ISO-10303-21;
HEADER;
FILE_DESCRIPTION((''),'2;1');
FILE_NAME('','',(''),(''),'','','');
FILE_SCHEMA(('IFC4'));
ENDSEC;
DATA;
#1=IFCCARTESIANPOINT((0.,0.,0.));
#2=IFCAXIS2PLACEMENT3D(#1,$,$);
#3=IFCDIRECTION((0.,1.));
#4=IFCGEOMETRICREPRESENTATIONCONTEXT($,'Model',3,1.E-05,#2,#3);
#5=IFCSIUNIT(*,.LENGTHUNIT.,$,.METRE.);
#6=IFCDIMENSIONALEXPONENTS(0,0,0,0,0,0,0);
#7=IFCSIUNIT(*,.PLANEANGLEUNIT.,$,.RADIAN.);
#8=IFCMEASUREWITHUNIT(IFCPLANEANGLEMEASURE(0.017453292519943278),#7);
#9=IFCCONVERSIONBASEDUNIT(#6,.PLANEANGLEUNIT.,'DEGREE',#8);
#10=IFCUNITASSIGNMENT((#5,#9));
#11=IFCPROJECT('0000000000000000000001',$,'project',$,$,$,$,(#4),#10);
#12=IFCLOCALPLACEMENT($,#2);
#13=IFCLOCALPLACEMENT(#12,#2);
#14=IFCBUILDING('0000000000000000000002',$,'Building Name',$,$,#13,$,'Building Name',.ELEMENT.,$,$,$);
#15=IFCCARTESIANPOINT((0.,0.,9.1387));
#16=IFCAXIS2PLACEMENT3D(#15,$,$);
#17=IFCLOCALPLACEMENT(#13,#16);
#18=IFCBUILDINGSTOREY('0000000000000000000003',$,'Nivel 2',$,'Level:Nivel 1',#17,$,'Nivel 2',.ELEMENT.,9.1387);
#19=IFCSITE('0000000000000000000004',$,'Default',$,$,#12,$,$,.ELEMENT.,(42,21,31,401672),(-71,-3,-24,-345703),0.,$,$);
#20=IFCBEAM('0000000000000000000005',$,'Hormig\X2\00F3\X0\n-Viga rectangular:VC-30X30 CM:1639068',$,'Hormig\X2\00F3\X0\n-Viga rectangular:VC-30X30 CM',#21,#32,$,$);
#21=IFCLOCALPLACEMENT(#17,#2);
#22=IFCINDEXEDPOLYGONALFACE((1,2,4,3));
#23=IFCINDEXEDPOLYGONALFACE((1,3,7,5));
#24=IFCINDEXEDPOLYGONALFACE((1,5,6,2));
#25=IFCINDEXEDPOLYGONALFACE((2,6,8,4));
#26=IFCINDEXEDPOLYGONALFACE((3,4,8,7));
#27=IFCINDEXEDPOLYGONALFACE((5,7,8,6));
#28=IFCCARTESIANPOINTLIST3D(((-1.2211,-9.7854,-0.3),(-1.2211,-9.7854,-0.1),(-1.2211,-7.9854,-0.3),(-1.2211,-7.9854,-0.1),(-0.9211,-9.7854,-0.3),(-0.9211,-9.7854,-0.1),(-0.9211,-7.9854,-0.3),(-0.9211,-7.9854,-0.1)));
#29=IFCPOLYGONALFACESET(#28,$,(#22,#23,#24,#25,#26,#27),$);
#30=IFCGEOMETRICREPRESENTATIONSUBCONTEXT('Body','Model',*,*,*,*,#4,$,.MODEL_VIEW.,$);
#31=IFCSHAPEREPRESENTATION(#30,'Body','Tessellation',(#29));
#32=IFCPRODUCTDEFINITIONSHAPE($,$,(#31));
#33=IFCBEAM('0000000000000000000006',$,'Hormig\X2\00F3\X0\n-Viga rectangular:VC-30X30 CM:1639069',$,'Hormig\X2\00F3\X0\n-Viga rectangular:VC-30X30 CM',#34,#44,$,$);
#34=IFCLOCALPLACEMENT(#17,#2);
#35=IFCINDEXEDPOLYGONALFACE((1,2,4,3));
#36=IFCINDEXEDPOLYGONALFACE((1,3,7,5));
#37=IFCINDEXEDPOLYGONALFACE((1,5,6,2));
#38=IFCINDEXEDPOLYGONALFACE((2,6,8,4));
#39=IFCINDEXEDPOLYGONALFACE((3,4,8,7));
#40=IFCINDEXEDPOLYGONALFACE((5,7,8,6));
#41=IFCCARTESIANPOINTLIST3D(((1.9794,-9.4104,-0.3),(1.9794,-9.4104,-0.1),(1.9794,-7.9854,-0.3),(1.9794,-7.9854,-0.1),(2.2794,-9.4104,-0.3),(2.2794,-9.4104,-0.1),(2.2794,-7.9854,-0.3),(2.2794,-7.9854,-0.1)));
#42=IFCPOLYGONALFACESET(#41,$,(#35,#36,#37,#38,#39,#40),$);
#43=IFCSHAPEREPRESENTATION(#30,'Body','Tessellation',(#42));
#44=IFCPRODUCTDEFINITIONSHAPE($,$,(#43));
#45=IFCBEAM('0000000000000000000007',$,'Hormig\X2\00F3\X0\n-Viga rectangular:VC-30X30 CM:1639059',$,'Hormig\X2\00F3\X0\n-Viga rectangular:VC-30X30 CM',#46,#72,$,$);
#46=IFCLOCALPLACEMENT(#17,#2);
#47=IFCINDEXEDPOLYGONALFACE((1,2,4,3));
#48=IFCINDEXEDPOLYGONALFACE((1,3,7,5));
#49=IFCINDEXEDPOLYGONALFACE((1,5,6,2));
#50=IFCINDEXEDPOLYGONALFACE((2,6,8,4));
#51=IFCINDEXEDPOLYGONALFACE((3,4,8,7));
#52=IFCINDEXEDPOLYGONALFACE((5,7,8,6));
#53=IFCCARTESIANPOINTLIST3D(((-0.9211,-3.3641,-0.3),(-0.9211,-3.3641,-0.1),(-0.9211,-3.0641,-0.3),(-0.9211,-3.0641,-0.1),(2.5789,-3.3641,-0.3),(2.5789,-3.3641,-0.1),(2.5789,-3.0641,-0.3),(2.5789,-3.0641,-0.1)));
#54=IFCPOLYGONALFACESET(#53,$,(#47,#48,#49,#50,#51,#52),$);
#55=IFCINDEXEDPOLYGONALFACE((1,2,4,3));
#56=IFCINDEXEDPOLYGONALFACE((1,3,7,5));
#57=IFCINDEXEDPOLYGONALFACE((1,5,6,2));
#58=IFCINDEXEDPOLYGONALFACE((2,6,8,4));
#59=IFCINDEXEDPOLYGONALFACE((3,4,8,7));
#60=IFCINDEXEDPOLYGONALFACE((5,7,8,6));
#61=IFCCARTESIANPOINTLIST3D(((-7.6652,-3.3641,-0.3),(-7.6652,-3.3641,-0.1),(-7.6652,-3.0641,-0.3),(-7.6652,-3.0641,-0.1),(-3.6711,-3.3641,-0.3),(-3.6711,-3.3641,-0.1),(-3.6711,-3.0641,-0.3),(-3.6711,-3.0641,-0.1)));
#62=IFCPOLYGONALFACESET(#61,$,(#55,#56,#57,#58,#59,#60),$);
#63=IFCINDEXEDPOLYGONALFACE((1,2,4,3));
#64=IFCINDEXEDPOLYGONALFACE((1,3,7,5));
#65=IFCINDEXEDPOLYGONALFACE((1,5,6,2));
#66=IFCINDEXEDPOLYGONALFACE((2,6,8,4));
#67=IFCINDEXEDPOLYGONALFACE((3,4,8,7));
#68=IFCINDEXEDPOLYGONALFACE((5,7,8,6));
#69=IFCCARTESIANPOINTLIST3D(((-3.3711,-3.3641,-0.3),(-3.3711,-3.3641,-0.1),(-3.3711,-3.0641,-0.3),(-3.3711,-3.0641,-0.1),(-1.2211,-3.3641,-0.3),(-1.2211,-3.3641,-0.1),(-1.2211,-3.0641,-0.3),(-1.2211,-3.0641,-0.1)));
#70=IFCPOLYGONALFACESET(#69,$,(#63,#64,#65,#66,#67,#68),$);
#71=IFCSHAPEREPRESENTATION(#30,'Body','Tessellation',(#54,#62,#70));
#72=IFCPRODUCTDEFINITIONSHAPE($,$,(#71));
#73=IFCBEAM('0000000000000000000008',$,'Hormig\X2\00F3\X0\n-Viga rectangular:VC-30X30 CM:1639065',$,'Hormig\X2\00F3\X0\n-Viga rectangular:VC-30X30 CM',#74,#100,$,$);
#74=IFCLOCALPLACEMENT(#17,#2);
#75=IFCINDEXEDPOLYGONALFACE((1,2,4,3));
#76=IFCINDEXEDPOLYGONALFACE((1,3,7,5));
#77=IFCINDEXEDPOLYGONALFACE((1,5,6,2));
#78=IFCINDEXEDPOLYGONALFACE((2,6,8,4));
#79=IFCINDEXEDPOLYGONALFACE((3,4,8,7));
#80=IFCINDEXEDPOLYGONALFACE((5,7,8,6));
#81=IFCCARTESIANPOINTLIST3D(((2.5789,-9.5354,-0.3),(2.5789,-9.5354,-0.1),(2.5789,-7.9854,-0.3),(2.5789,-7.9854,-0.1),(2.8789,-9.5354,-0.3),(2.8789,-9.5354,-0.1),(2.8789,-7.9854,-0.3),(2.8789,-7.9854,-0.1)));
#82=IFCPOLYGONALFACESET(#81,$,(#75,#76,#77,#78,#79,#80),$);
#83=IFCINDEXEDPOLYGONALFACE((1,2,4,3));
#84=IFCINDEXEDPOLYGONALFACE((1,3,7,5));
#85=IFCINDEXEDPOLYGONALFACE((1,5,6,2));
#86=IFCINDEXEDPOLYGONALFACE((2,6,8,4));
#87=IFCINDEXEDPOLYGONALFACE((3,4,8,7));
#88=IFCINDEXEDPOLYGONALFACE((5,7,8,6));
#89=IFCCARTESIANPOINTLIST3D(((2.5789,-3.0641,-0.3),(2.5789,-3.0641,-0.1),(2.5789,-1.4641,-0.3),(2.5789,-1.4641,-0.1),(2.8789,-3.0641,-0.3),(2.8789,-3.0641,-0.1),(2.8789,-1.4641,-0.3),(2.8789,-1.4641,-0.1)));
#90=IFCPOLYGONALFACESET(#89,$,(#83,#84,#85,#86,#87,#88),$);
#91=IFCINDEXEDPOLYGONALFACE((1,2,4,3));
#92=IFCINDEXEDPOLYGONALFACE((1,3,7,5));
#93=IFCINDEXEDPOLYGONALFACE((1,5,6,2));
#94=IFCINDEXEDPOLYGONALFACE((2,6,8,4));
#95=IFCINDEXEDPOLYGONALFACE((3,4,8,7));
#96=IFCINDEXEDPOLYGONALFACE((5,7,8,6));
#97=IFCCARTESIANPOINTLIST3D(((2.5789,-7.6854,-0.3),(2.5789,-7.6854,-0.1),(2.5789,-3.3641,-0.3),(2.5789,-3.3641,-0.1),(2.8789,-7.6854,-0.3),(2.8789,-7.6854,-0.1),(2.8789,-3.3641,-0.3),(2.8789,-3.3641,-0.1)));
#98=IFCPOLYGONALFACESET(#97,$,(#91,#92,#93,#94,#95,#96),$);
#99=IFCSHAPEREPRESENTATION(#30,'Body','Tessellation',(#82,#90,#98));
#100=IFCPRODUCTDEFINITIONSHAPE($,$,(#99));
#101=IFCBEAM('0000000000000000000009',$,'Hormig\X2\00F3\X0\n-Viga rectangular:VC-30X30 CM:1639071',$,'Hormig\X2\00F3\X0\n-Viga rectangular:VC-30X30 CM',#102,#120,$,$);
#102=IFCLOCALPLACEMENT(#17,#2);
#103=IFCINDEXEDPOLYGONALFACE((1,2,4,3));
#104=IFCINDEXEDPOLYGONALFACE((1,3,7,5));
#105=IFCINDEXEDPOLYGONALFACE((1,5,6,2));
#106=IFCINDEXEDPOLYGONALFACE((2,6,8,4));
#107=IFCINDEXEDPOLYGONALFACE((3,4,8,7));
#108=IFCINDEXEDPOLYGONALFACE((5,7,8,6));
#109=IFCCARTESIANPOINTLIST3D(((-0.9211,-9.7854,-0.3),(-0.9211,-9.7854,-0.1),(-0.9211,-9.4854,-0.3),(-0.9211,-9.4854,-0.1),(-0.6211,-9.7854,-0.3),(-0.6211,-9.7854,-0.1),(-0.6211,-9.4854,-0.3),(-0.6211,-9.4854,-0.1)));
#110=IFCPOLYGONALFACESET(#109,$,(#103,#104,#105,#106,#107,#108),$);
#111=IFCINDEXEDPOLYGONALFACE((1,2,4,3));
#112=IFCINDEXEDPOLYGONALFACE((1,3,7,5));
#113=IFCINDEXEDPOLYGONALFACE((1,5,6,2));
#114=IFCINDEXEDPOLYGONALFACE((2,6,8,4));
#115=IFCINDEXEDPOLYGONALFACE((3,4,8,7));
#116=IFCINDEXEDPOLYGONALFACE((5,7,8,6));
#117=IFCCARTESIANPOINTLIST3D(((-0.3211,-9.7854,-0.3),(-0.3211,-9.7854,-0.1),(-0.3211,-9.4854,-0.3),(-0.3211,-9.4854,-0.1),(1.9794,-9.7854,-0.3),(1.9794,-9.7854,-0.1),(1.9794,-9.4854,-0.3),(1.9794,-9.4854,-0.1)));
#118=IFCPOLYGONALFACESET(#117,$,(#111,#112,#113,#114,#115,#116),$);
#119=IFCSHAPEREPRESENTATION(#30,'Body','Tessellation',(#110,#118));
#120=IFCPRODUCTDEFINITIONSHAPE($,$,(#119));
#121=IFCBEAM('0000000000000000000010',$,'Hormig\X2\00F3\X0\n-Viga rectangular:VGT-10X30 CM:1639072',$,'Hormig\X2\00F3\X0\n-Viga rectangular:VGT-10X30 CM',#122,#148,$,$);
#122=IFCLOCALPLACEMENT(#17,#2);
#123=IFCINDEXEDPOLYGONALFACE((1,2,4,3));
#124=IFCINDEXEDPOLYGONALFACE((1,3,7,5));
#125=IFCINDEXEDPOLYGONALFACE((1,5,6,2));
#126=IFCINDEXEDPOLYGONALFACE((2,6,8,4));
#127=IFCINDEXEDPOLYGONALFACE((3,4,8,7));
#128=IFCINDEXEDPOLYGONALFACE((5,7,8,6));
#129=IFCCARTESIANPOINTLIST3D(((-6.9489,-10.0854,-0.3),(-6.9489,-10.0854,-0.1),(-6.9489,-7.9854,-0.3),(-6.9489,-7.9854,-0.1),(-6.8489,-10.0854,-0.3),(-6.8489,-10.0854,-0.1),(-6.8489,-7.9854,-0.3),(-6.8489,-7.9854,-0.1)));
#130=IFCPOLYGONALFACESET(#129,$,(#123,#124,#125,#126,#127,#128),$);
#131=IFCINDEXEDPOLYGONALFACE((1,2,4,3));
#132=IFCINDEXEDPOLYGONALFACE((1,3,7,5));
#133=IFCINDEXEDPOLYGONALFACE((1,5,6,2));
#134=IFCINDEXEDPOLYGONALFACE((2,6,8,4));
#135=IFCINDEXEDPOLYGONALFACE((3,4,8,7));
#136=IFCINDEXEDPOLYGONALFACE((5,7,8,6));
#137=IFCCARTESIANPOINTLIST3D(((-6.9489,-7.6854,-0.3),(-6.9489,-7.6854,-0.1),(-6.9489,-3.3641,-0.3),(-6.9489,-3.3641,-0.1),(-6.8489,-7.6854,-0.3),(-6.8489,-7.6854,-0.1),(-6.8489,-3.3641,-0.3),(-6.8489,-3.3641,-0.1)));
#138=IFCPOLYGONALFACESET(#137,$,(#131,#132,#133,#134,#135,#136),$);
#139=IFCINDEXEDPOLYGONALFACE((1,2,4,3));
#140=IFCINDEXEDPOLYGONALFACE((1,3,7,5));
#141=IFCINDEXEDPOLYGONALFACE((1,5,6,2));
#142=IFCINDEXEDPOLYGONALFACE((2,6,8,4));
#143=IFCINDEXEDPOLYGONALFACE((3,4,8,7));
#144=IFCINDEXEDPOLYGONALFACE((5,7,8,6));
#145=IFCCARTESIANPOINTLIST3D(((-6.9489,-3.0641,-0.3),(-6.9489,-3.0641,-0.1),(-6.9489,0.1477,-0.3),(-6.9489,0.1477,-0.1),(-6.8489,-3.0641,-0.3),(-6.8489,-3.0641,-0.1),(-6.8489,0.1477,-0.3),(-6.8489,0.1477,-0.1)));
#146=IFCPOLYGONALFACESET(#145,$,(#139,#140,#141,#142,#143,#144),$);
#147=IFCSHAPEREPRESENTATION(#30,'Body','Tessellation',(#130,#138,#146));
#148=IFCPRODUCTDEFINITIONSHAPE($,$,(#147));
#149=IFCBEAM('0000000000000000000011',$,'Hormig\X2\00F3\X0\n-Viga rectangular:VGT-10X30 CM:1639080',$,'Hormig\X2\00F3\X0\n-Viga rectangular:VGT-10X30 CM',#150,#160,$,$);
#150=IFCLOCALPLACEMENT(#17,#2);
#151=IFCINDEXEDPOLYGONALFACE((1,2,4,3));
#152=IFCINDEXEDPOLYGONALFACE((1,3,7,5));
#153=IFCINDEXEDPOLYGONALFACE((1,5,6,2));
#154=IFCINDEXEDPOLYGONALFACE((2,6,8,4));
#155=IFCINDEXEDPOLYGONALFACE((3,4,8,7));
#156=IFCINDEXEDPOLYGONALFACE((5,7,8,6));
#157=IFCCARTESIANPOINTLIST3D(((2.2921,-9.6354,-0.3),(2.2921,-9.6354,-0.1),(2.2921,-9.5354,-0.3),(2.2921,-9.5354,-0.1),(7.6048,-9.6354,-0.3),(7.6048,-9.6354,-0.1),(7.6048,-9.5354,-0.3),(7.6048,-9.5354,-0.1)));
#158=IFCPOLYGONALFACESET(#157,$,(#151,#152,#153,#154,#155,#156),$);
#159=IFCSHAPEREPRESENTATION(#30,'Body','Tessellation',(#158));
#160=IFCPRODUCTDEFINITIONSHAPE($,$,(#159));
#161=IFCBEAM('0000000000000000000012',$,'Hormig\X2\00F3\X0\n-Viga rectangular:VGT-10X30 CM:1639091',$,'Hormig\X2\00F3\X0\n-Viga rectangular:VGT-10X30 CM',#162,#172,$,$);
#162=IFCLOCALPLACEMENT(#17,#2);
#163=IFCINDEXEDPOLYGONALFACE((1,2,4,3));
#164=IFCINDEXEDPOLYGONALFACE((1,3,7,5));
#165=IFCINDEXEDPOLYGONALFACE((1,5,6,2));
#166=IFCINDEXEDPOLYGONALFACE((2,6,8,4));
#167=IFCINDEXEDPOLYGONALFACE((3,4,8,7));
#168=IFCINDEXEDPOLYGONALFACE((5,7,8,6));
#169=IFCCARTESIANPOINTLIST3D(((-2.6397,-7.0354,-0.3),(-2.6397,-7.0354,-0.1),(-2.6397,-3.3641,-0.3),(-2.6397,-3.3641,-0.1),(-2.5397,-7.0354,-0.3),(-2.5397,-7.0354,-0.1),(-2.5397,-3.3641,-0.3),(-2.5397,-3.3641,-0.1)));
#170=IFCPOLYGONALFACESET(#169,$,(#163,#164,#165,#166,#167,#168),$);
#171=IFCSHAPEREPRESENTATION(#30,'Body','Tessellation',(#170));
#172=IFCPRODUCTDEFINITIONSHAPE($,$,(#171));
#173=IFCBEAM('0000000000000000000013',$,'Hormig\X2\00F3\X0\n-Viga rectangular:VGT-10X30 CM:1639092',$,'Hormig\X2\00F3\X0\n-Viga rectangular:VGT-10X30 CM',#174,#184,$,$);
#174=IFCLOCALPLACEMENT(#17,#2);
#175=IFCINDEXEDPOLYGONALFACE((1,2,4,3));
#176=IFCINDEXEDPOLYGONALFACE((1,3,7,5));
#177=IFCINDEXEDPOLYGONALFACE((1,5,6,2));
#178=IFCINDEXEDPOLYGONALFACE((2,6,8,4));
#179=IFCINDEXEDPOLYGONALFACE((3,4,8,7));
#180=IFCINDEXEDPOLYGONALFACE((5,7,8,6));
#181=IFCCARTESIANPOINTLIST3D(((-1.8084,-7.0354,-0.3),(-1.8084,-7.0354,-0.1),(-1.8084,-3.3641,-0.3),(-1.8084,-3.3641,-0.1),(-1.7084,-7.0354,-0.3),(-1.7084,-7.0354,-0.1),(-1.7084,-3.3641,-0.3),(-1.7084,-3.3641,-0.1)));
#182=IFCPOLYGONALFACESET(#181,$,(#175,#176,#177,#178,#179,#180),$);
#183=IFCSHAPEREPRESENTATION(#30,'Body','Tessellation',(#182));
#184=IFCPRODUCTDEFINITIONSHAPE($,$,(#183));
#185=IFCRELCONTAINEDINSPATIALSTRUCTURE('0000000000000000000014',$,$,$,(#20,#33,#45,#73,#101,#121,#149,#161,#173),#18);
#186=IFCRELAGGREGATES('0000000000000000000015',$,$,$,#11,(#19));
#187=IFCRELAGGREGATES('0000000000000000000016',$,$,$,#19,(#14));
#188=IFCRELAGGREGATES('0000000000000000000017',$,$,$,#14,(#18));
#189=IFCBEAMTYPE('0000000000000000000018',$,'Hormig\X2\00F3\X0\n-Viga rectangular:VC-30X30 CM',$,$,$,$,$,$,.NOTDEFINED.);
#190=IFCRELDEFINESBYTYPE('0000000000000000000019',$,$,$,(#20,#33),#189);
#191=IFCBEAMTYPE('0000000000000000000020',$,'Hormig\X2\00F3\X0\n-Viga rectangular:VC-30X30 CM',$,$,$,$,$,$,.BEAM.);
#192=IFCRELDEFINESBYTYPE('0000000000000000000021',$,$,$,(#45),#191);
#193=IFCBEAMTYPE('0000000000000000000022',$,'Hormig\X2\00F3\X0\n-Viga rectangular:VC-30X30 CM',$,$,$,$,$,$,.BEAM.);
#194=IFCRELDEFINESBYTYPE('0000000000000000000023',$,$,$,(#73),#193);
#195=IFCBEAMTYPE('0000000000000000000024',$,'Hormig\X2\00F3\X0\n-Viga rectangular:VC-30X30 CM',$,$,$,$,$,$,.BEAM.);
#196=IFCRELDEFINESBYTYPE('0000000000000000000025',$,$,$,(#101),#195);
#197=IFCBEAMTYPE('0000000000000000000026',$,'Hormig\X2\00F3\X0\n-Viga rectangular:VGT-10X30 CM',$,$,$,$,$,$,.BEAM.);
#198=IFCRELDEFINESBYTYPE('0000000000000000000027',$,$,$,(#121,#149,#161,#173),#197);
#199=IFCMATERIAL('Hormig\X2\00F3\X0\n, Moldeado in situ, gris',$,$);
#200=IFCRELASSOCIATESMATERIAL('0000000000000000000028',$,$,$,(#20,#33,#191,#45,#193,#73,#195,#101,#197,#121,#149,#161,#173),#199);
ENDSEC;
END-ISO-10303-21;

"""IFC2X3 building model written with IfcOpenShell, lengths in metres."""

from ifc_helpers import new_model, entity, si_unit, converted_unit, direction, frame, frame_2d, origin, place, context, subcontext, project, spatial, rectangle, extrude, source, transform, mapped, material, type_object, type_shapes, element, save


model = new_model("IFC2X3")

# Units and contexts
model_context = context("Model", 3, precision=1e-05, world=origin(), true_north=direction((0.0, 1.0)))
body_context = subcontext(model_context, "Body", "Model", "MODEL_VIEW")
ifc_project = project(units=[si_unit("LENGTHUNIT", "METRE"), converted_unit("PLANEANGLEUNIT", "DEGREE", entity("IfcPlaneAngleMeasure", 0.017453292519943278), si_unit("PLANEANGLEUNIT", "RADIAN"), dimensions=[0, 0, 0, 0, 0, 0, 0])], contexts=[model_context])

# Site, building, storey
site_placement = place(None, origin())
site = spatial("IfcSite", under=ifc_project, at=site_placement, Name="Default", CompositionType="ELEMENT", RefLatitude=(42, 21, 31, 401672), RefLongitude=(-71, -3, -24, -345703), RefElevation=0.0)
building_placement = place(site_placement, origin())
building = spatial("IfcBuilding", under=site, at=building_placement, Name="Building Name", LongName="Building Name", CompositionType="ELEMENT")
storey_placement = place(building_placement, frame((0.0, 0.0, 9.1387)))
storey = spatial("IfcBuildingStorey", under=building, at=storey_placement, Name="Nivel 2", ObjectType="Level:Nivel 1", LongName="Nivel 2", CompositionType="ELEMENT", Elevation=9.1387)

# Beams
ifc_material = material(Name="Hormigón, Moldeado in situ, gris")
beam_type_1 = type_object("IfcBeamType", Name="Hormigón-Viga rectangular:VC-30X30 CM", PredefinedType="NOTDEFINED")
beam_1_placement = place(storey_placement, frame((-1.0711, -7.8354, 0.0), z_axis=(0.0, 0.0, 1.0), x_axis=(0.0, -1.0, 0.0)))
element("IfcBeam", 1, at=beam_1_placement, inside=storey, type_object=beam_type_1, material=ifc_material, Name="Hormigón-Viga rectangular:VC-30X30 CM:1639068", ObjectType="Hormigón-Viga rectangular:VC-30X30 CM", context=body_context, shape_type="SweptSolid", body=[
    extrude(rectangle(XDim=0.2, YDim=0.3, at=frame_2d((0.0, 0.0), x_axis=(1.0, 0.0))), frame((0.15, 0.0, -0.2), z_axis=(1.0, 0.0, 0.0), x_axis=(0.0, 0.0, -1.0)), (0.0, 0.0, 1.0), 1.8),
])
beam_2_placement = place(storey_placement, frame((2.1294, -7.8354, 0.0), z_axis=(0.0, 0.0, 1.0), x_axis=(0.0, -1.0, 0.0)))
element("IfcBeam", 2, at=beam_2_placement, inside=storey, type_object=beam_type_1, material=ifc_material, Name="Hormigón-Viga rectangular:VC-30X30 CM:1639069", ObjectType="Hormigón-Viga rectangular:VC-30X30 CM", context=body_context, shape_type="SweptSolid", body=[
    extrude(rectangle(XDim=0.2, YDim=0.3, at=frame_2d((0.0, 0.0), x_axis=(1.0, 0.0))), frame((0.15, 0.0, -0.2), z_axis=(1.0, 0.0, 0.0), x_axis=(0.0, 0.0, -1.0)), (0.0, 0.0, 1.0), 1.425),
])
beam_type_2 = type_object("IfcBeamType", Name="Hormigón-Viga rectangular:VC-30X30 CM", PredefinedType="BEAM", material=ifc_material)
shared_shape_1 = source(origin(), body_context, "Body", "SweptSolid", [
    extrude(rectangle(XDim=0.2, YDim=0.3, at=frame_2d((0.0, 0.0), x_axis=(1.0, 0.0))), frame((-0.9211, -3.2141, 8.9387), z_axis=(1.0, 0.0, 0.0), x_axis=(0.0, 0.0, -1.0)), (0.0, 0.0, 1.0), 3.5),
    extrude(rectangle(XDim=0.2, YDim=0.3, at=frame_2d((0.0, 0.0), x_axis=(1.0, 0.0))), frame((-7.6652, -3.2141, 8.9387), z_axis=(1.0, 0.0, 0.0), x_axis=(0.0, 0.0, -1.0)), (0.0, 0.0, 1.0), 3.9942),
    extrude(rectangle(XDim=0.2, YDim=0.3, at=frame_2d((0.0, 0.0), x_axis=(1.0, 0.0))), frame((-3.3711, -3.2141, 8.9387), z_axis=(1.0, 0.0, 0.0), x_axis=(0.0, 0.0, -1.0)), (0.0, 0.0, 1.0), 2.15),
])
type_shapes(beam_type_2, [shared_shape_1])
beam_3_placement = place(storey_placement, frame((0.0, 0.0, -9.1387)))
element("IfcBeam", 3, at=beam_3_placement, inside=storey, type_object=beam_type_2, material=ifc_material, Name="Hormigón-Viga rectangular:VC-30X30 CM:1639059", ObjectType="Hormigón-Viga rectangular:VC-30X30 CM", context=body_context, shape_type="MappedRepresentation", body=[
    mapped(shared_shape_1, transform((0.0, 0.0, 0.0), scale=1.0)),
])
beam_type_3 = type_object("IfcBeamType", Name="Hormigón-Viga rectangular:VC-30X30 CM", PredefinedType="BEAM", material=ifc_material)
shared_shape_2 = source(origin(), body_context, "Body", "SweptSolid", [
    extrude(rectangle(XDim=0.2, YDim=0.3, at=frame_2d((0.0, 0.0), x_axis=(0.0, 1.0))), frame((2.7289, -7.9854, 8.9387), z_axis=(0.0, -1.0, 0.0), x_axis=(-1.0, 0.0, 0.0)), (0.0, 0.0, 1.0), 1.55),
    extrude(rectangle(XDim=0.2, YDim=0.3, at=frame_2d((0.0, 0.0), x_axis=(0.0, 1.0))), frame((2.7289, -1.4641, 8.9387), z_axis=(0.0, -1.0, 0.0), x_axis=(-1.0, 0.0, 0.0)), (0.0, 0.0, 1.0), 1.6),
    extrude(rectangle(XDim=0.2, YDim=0.3, at=frame_2d((0.0, 0.0), x_axis=(0.0, 1.0))), frame((2.7289, -3.3641, 8.9387), z_axis=(0.0, -1.0, 0.0), x_axis=(-1.0, 0.0, 0.0)), (0.0, 0.0, 1.0), 4.3214),
])
type_shapes(beam_type_3, [shared_shape_2])
beam_4_placement = place(storey_placement, frame((0.0, 0.0, -9.1387)))
element("IfcBeam", 4, at=beam_4_placement, inside=storey, type_object=beam_type_3, material=ifc_material, Name="Hormigón-Viga rectangular:VC-30X30 CM:1639065", ObjectType="Hormigón-Viga rectangular:VC-30X30 CM", context=body_context, shape_type="MappedRepresentation", body=[
    mapped(shared_shape_2, transform((0.0, 0.0, 0.0), scale=1.0)),
])
beam_type_4 = type_object("IfcBeamType", Name="Hormigón-Viga rectangular:VC-30X30 CM", PredefinedType="BEAM", material=ifc_material)
shared_shape_3 = source(origin(), body_context, "Body", "SweptSolid", [
    extrude(rectangle(XDim=0.2, YDim=0.3, at=frame_2d((0.0, 0.0), x_axis=(1.0, 0.0))), frame((-0.9211, -9.6354, 8.9387), z_axis=(1.0, 0.0, 0.0), x_axis=(0.0, 0.0, -1.0)), (0.0, 0.0, 1.0), 0.3),
    extrude(rectangle(XDim=0.2, YDim=0.3, at=frame_2d((0.0, 0.0), x_axis=(1.0, 0.0))), frame((-0.3211, -9.6354, 8.9387), z_axis=(1.0, 0.0, 0.0), x_axis=(0.0, 0.0, -1.0)), (0.0, 0.0, 1.0), 2.3005),
])
type_shapes(beam_type_4, [shared_shape_3])
beam_5_placement = place(storey_placement, frame((0.0, 0.0, -9.1387)))
element("IfcBeam", 5, at=beam_5_placement, inside=storey, type_object=beam_type_4, material=ifc_material, Name="Hormigón-Viga rectangular:VC-30X30 CM:1639071", ObjectType="Hormigón-Viga rectangular:VC-30X30 CM", context=body_context, shape_type="MappedRepresentation", body=[
    mapped(shared_shape_3, transform((0.0, 0.0, 0.0), scale=1.0)),
])
beam_type_5 = type_object("IfcBeamType", Name="Hormigón-Viga rectangular:VGT-10X30 CM", PredefinedType="BEAM", material=ifc_material)
shared_shape_4 = source(origin(), body_context, "Body", "SweptSolid", [
    extrude(rectangle(XDim=0.2, YDim=0.1, at=frame_2d((0.0, 0.0), x_axis=(0.0, 1.0))), frame((-6.8989, -7.9854, 8.9387), z_axis=(0.0, -1.0, 0.0), x_axis=(-1.0, 0.0, 0.0)), (0.0, 0.0, 1.0), 2.1),
    extrude(rectangle(XDim=0.2, YDim=0.1, at=frame_2d((0.0, 0.0), x_axis=(0.0, 1.0))), frame((-6.8989, -3.3641, 8.9387), z_axis=(0.0, -1.0, 0.0), x_axis=(-1.0, 0.0, 0.0)), (0.0, 0.0, 1.0), 4.3214),
    extrude(rectangle(XDim=0.2, YDim=0.1, at=frame_2d((0.0, 0.0), x_axis=(0.0, 1.0))), frame((-6.8989, 0.1477, 8.9387), z_axis=(0.0, -1.0, 0.0), x_axis=(-1.0, 0.0, 0.0)), (0.0, 0.0, 1.0), 3.2118),
])
type_shapes(beam_type_5, [shared_shape_4])
beam_6_placement = place(storey_placement, frame((0.0, 0.0, -9.1387)))
element("IfcBeam", 6, at=beam_6_placement, inside=storey, type_object=beam_type_5, material=ifc_material, Name="Hormigón-Viga rectangular:VGT-10X30 CM:1639072", ObjectType="Hormigón-Viga rectangular:VGT-10X30 CM", context=body_context, shape_type="MappedRepresentation", body=[
    mapped(shared_shape_4, transform((0.0, 0.0, 0.0), scale=1.0)),
])
beam_7_placement = place(storey_placement, frame((2.2921, -9.5854, 0.0)))
element("IfcBeam", 7, at=beam_7_placement, inside=storey, type_object=beam_type_5, material=ifc_material, Name="Hormigón-Viga rectangular:VGT-10X30 CM:1639080", ObjectType="Hormigón-Viga rectangular:VGT-10X30 CM", context=body_context, shape_type="SweptSolid", body=[
    extrude(rectangle(XDim=0.2, YDim=0.1, at=frame_2d((0.0, 0.0), x_axis=(1.0, 0.0))), frame((0.0, 0.0, -0.2), z_axis=(1.0, 0.0, 0.0), x_axis=(0.0, 0.0, -1.0)), (0.0, 0.0, 1.0), 5.3126),
])
beam_8_placement = place(storey_placement, frame((-2.5897, -7.1354, 0.0), z_axis=(0.0, 0.0, 1.0), x_axis=(0.0, 1.0, 0.0)))
element("IfcBeam", 8, at=beam_8_placement, inside=storey, type_object=beam_type_5, material=ifc_material, Name="Hormigón-Viga rectangular:VGT-10X30 CM:1639091", ObjectType="Hormigón-Viga rectangular:VGT-10X30 CM", context=body_context, shape_type="SweptSolid", body=[
    extrude(rectangle(XDim=0.2, YDim=0.1, at=frame_2d((0.0, 0.0), x_axis=(1.0, 0.0))), frame((0.1, 0.0, -0.2), z_axis=(1.0, 0.0, 0.0), x_axis=(0.0, 0.0, -1.0)), (0.0, 0.0, 1.0), 3.6714),
])
beam_9_placement = place(storey_placement, frame((-1.7584, -7.1354, 0.0), z_axis=(0.0, 0.0, 1.0), x_axis=(0.0, 1.0, 0.0)))
element("IfcBeam", 9, at=beam_9_placement, inside=storey, type_object=beam_type_5, material=ifc_material, Name="Hormigón-Viga rectangular:VGT-10X30 CM:1639092", ObjectType="Hormigón-Viga rectangular:VGT-10X30 CM", context=body_context, shape_type="SweptSolid", body=[
    extrude(rectangle(XDim=0.2, YDim=0.1, at=frame_2d((0.0, 0.0), x_axis=(1.0, 0.0))), frame((0.1, 0.0, -0.2), z_axis=(1.0, 0.0, 0.0), x_axis=(0.0, 0.0, -1.0)), (0.0, 0.0, 1.0), 3.6714),
])

save(model, "model.ifc")
